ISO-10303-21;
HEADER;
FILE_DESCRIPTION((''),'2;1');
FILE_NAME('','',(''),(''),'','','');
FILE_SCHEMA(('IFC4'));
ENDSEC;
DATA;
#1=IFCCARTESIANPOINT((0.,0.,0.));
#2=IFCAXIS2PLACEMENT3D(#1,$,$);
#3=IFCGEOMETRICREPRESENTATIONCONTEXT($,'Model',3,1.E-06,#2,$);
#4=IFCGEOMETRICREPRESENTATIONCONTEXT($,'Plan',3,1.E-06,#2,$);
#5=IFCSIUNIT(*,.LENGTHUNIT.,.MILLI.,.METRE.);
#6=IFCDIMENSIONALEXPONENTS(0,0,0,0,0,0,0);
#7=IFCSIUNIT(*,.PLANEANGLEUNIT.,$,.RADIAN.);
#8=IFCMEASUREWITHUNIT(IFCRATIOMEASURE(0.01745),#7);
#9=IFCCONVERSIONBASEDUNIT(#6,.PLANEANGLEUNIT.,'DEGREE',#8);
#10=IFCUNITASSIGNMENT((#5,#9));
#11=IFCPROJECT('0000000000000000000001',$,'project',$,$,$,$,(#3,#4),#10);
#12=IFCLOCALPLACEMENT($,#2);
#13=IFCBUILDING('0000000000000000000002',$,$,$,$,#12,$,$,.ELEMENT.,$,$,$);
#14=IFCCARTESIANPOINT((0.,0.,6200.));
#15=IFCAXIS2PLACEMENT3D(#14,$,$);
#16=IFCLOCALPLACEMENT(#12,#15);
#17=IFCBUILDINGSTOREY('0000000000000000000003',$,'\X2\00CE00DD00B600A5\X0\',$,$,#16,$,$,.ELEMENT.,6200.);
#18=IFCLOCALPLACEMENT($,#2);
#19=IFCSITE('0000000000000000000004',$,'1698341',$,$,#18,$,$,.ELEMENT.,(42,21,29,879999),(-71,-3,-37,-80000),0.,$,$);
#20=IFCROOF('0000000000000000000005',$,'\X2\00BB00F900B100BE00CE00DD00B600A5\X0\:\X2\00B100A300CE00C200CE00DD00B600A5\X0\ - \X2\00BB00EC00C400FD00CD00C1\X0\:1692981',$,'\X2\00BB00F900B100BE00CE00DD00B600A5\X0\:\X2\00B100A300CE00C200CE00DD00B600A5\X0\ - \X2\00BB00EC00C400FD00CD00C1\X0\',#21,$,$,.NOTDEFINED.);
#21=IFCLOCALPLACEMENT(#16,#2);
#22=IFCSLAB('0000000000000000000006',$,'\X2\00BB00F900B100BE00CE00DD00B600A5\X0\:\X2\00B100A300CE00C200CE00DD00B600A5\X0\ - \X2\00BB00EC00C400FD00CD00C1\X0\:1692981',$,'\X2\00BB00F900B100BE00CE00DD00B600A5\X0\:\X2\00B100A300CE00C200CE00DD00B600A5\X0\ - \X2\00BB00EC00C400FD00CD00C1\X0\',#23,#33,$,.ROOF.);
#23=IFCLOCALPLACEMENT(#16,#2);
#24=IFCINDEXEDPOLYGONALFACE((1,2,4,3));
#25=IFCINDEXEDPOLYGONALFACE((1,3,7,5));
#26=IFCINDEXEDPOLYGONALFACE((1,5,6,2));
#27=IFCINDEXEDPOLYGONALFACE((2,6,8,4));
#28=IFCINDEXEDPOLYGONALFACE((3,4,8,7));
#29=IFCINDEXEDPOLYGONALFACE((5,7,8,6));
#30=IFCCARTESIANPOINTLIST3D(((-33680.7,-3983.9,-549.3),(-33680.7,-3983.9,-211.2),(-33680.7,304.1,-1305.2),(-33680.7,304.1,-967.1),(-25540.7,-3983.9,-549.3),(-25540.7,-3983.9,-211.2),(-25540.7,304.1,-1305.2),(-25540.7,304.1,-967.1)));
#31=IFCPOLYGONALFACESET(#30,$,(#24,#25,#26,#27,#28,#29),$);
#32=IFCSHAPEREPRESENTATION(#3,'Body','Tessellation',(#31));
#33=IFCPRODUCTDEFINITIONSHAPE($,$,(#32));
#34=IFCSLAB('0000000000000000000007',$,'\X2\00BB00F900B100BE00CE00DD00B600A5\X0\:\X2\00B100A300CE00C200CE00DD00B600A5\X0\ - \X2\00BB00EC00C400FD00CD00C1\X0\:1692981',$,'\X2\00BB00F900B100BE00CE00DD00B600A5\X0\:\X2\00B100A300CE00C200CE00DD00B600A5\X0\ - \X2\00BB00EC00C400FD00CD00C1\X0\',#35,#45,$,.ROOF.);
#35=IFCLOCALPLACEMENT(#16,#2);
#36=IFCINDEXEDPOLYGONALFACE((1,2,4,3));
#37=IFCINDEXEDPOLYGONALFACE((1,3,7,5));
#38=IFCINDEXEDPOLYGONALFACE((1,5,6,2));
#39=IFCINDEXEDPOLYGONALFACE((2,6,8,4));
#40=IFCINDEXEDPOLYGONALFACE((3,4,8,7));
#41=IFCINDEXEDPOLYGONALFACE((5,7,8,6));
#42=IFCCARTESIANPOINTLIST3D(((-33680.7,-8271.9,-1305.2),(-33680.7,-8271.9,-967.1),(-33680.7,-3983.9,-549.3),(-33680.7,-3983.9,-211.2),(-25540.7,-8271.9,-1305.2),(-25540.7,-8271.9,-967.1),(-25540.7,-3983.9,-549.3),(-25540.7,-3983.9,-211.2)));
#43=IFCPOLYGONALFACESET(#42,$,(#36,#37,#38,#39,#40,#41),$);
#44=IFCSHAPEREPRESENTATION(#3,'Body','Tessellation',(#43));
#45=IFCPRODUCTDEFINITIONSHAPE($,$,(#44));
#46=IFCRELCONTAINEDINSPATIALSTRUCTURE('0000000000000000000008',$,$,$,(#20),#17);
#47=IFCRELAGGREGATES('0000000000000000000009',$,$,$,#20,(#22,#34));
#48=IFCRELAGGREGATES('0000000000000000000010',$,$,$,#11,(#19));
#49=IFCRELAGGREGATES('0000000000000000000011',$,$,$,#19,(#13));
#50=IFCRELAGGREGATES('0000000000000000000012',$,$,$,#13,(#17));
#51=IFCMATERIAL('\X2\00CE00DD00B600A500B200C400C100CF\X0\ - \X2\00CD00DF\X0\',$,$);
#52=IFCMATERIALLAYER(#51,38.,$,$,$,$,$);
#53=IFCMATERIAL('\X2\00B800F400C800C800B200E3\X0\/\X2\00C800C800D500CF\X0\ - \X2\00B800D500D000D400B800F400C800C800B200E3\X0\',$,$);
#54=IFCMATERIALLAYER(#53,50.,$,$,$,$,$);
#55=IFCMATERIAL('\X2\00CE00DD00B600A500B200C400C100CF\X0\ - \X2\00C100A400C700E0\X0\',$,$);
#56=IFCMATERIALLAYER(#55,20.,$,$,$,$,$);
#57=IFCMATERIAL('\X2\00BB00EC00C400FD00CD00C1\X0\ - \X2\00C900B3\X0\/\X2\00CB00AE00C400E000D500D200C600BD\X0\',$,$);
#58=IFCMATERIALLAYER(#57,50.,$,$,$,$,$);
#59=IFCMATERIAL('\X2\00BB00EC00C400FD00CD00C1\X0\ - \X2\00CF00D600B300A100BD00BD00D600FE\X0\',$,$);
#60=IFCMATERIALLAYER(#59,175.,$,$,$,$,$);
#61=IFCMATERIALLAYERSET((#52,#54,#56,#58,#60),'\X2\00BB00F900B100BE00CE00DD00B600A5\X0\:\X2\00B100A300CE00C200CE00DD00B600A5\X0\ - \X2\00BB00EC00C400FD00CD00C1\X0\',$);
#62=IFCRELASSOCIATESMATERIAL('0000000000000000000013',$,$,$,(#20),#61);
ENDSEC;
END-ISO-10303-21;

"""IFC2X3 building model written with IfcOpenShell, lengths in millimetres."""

from ifc_helpers import new_model, entity, si_unit, converted_unit, frame, frame_2d, origin, place, context, project, spatial, rectangle, extrude, material, layer, layer_set, layer_usage, element, aggregate, save


model = new_model("IFC2X3")

# Units and contexts
model_context = context("Model", 3, precision=1e-06, world=origin())
plan_context = context("Plan", 3, precision=1e-06, world=origin())
ifc_project = project(units=[si_unit("LENGTHUNIT", "METRE", prefix="MILLI"), converted_unit("PLANEANGLEUNIT", "DEGREE", entity("IfcRatioMeasure", 0.01745), si_unit("PLANEANGLEUNIT", "RADIAN"), dimensions=[0, 0, 0, 0, 0, 0, 0])], contexts=[model_context, plan_context])

# Site, building, storey
site_placement = place(None, origin())
site = spatial("IfcSite", under=ifc_project, at=site_placement, Name="1698341", CompositionType="ELEMENT", RefLatitude=(42, 21, 29, 879999), RefLongitude=(-71, -3, -37, -80000), RefElevation=0.0)
building_placement = place(None, origin())
building = spatial("IfcBuilding", under=site, at=building_placement, CompositionType="ELEMENT")
storey_placement = place(building_placement, frame((0.0, 0.0, 6200.0)))
storey = spatial("IfcBuildingStorey", under=building, at=storey_placement, Name="ÎÝ¶¥", CompositionType="ELEMENT", Elevation=6200.0)

# Roof, slabs
ifc_material_1 = material(Name="ÎÝ¶¥²ÄÁÏ - Íß")
ifc_layer_1 = layer(ifc_material_1, 38.0)
ifc_material_2 = material(Name="¸ôÈÈ²ã/ÈÈÕÏ - ¸ÕÐÔ¸ôÈÈ²ã")
ifc_layer_2 = layer(ifc_material_2, 50.0)
ifc_material_3 = material(Name="ÎÝ¶¥²ÄÁÏ - Á¤Çà")
ifc_layer_3 = layer(ifc_material_3, 20.0)
ifc_material_4 = material(Name="»ìÄýÍÁ - É³/Ë®ÄàÕÒÆ½")
ifc_layer_4 = layer(ifc_material_4, 50.0)
ifc_material_5 = material(Name="»ìÄýÍÁ - ÏÖ³¡½½Öþ")
ifc_layer_5 = layer(ifc_material_5, 175.0)
ifc_layer_set = layer_set([ifc_layer_1, ifc_layer_2, ifc_layer_3, ifc_layer_4, ifc_layer_5], Name="»ù±¾ÎÝ¶¥:±£ÎÂÎÝ¶¥ - »ìÄýÍÁ")
ifc_layer_usage = layer_usage(ifc_layer_set, "AXIS3", "NEGATIVE", 0.0)
roof_placement = place(storey_placement, origin())
roof = element("IfcRoof", 1, at=roof_placement, inside=storey, material=ifc_layer_usage, Name="»ù±¾ÎÝ¶¥:±£ÎÂÎÝ¶¥ - »ìÄýÍÁ:1692981", ObjectType="»ù±¾ÎÝ¶¥:±£ÎÂÎÝ¶¥ - »ìÄýÍÁ", ShapeType="NOTDEFINED")
slab_1_placement = place(roof_placement, frame((-33680.7, -8271.9, -1305.3)))
slab_1 = element("IfcSlab", 2, at=slab_1_placement, Name="»ù±¾ÎÝ¶¥:±£ÎÂÎÝ¶¥ - »ìÄýÍÁ:1692981", ObjectType="»ù±¾ÎÝ¶¥:±£ÎÂÎÝ¶¥ - »ìÄýÍÁ", PredefinedType="ROOF", context=model_context, shape_type="SweptSolid", body=[
    extrude(rectangle(XDim=8140.0, YDim=4354.1, at=frame_2d((0.0, 0.0), x_axis=(-1.0, 0.0))), frame((4070.0, 6431.9, 378.0), z_axis=(0.0, 0.1736, 0.9848), x_axis=(1.0, 0.0, 0.0)), (0.0, -0.1736, 0.9848), 338.1),
])
slab_2_placement = place(roof_placement, frame((-33680.7, -8271.9, -1305.3)))
slab_2 = element("IfcSlab", 3, at=slab_2_placement, Name="»ù±¾ÎÝ¶¥:±£ÎÂÎÝ¶¥ - »ìÄýÍÁ:1692981", ObjectType="»ù±¾ÎÝ¶¥:±£ÎÂÎÝ¶¥ - »ìÄýÍÁ", PredefinedType="ROOF", context=model_context, shape_type="SweptSolid", body=[
    extrude(rectangle(XDim=8140.0, YDim=4354.1, at=frame_2d((0.0, 0.0), x_axis=(-1.0, 0.0))), frame((4070.0, 2144.0, 378.0), z_axis=(0.0, -0.1736, 0.9848), x_axis=(1.0, 0.0, 0.0)), (0.0, 0.1736, 0.9848), 338.1),
])
aggregate(roof, [slab_1, slab_2])

save(model, "model.ifc")
